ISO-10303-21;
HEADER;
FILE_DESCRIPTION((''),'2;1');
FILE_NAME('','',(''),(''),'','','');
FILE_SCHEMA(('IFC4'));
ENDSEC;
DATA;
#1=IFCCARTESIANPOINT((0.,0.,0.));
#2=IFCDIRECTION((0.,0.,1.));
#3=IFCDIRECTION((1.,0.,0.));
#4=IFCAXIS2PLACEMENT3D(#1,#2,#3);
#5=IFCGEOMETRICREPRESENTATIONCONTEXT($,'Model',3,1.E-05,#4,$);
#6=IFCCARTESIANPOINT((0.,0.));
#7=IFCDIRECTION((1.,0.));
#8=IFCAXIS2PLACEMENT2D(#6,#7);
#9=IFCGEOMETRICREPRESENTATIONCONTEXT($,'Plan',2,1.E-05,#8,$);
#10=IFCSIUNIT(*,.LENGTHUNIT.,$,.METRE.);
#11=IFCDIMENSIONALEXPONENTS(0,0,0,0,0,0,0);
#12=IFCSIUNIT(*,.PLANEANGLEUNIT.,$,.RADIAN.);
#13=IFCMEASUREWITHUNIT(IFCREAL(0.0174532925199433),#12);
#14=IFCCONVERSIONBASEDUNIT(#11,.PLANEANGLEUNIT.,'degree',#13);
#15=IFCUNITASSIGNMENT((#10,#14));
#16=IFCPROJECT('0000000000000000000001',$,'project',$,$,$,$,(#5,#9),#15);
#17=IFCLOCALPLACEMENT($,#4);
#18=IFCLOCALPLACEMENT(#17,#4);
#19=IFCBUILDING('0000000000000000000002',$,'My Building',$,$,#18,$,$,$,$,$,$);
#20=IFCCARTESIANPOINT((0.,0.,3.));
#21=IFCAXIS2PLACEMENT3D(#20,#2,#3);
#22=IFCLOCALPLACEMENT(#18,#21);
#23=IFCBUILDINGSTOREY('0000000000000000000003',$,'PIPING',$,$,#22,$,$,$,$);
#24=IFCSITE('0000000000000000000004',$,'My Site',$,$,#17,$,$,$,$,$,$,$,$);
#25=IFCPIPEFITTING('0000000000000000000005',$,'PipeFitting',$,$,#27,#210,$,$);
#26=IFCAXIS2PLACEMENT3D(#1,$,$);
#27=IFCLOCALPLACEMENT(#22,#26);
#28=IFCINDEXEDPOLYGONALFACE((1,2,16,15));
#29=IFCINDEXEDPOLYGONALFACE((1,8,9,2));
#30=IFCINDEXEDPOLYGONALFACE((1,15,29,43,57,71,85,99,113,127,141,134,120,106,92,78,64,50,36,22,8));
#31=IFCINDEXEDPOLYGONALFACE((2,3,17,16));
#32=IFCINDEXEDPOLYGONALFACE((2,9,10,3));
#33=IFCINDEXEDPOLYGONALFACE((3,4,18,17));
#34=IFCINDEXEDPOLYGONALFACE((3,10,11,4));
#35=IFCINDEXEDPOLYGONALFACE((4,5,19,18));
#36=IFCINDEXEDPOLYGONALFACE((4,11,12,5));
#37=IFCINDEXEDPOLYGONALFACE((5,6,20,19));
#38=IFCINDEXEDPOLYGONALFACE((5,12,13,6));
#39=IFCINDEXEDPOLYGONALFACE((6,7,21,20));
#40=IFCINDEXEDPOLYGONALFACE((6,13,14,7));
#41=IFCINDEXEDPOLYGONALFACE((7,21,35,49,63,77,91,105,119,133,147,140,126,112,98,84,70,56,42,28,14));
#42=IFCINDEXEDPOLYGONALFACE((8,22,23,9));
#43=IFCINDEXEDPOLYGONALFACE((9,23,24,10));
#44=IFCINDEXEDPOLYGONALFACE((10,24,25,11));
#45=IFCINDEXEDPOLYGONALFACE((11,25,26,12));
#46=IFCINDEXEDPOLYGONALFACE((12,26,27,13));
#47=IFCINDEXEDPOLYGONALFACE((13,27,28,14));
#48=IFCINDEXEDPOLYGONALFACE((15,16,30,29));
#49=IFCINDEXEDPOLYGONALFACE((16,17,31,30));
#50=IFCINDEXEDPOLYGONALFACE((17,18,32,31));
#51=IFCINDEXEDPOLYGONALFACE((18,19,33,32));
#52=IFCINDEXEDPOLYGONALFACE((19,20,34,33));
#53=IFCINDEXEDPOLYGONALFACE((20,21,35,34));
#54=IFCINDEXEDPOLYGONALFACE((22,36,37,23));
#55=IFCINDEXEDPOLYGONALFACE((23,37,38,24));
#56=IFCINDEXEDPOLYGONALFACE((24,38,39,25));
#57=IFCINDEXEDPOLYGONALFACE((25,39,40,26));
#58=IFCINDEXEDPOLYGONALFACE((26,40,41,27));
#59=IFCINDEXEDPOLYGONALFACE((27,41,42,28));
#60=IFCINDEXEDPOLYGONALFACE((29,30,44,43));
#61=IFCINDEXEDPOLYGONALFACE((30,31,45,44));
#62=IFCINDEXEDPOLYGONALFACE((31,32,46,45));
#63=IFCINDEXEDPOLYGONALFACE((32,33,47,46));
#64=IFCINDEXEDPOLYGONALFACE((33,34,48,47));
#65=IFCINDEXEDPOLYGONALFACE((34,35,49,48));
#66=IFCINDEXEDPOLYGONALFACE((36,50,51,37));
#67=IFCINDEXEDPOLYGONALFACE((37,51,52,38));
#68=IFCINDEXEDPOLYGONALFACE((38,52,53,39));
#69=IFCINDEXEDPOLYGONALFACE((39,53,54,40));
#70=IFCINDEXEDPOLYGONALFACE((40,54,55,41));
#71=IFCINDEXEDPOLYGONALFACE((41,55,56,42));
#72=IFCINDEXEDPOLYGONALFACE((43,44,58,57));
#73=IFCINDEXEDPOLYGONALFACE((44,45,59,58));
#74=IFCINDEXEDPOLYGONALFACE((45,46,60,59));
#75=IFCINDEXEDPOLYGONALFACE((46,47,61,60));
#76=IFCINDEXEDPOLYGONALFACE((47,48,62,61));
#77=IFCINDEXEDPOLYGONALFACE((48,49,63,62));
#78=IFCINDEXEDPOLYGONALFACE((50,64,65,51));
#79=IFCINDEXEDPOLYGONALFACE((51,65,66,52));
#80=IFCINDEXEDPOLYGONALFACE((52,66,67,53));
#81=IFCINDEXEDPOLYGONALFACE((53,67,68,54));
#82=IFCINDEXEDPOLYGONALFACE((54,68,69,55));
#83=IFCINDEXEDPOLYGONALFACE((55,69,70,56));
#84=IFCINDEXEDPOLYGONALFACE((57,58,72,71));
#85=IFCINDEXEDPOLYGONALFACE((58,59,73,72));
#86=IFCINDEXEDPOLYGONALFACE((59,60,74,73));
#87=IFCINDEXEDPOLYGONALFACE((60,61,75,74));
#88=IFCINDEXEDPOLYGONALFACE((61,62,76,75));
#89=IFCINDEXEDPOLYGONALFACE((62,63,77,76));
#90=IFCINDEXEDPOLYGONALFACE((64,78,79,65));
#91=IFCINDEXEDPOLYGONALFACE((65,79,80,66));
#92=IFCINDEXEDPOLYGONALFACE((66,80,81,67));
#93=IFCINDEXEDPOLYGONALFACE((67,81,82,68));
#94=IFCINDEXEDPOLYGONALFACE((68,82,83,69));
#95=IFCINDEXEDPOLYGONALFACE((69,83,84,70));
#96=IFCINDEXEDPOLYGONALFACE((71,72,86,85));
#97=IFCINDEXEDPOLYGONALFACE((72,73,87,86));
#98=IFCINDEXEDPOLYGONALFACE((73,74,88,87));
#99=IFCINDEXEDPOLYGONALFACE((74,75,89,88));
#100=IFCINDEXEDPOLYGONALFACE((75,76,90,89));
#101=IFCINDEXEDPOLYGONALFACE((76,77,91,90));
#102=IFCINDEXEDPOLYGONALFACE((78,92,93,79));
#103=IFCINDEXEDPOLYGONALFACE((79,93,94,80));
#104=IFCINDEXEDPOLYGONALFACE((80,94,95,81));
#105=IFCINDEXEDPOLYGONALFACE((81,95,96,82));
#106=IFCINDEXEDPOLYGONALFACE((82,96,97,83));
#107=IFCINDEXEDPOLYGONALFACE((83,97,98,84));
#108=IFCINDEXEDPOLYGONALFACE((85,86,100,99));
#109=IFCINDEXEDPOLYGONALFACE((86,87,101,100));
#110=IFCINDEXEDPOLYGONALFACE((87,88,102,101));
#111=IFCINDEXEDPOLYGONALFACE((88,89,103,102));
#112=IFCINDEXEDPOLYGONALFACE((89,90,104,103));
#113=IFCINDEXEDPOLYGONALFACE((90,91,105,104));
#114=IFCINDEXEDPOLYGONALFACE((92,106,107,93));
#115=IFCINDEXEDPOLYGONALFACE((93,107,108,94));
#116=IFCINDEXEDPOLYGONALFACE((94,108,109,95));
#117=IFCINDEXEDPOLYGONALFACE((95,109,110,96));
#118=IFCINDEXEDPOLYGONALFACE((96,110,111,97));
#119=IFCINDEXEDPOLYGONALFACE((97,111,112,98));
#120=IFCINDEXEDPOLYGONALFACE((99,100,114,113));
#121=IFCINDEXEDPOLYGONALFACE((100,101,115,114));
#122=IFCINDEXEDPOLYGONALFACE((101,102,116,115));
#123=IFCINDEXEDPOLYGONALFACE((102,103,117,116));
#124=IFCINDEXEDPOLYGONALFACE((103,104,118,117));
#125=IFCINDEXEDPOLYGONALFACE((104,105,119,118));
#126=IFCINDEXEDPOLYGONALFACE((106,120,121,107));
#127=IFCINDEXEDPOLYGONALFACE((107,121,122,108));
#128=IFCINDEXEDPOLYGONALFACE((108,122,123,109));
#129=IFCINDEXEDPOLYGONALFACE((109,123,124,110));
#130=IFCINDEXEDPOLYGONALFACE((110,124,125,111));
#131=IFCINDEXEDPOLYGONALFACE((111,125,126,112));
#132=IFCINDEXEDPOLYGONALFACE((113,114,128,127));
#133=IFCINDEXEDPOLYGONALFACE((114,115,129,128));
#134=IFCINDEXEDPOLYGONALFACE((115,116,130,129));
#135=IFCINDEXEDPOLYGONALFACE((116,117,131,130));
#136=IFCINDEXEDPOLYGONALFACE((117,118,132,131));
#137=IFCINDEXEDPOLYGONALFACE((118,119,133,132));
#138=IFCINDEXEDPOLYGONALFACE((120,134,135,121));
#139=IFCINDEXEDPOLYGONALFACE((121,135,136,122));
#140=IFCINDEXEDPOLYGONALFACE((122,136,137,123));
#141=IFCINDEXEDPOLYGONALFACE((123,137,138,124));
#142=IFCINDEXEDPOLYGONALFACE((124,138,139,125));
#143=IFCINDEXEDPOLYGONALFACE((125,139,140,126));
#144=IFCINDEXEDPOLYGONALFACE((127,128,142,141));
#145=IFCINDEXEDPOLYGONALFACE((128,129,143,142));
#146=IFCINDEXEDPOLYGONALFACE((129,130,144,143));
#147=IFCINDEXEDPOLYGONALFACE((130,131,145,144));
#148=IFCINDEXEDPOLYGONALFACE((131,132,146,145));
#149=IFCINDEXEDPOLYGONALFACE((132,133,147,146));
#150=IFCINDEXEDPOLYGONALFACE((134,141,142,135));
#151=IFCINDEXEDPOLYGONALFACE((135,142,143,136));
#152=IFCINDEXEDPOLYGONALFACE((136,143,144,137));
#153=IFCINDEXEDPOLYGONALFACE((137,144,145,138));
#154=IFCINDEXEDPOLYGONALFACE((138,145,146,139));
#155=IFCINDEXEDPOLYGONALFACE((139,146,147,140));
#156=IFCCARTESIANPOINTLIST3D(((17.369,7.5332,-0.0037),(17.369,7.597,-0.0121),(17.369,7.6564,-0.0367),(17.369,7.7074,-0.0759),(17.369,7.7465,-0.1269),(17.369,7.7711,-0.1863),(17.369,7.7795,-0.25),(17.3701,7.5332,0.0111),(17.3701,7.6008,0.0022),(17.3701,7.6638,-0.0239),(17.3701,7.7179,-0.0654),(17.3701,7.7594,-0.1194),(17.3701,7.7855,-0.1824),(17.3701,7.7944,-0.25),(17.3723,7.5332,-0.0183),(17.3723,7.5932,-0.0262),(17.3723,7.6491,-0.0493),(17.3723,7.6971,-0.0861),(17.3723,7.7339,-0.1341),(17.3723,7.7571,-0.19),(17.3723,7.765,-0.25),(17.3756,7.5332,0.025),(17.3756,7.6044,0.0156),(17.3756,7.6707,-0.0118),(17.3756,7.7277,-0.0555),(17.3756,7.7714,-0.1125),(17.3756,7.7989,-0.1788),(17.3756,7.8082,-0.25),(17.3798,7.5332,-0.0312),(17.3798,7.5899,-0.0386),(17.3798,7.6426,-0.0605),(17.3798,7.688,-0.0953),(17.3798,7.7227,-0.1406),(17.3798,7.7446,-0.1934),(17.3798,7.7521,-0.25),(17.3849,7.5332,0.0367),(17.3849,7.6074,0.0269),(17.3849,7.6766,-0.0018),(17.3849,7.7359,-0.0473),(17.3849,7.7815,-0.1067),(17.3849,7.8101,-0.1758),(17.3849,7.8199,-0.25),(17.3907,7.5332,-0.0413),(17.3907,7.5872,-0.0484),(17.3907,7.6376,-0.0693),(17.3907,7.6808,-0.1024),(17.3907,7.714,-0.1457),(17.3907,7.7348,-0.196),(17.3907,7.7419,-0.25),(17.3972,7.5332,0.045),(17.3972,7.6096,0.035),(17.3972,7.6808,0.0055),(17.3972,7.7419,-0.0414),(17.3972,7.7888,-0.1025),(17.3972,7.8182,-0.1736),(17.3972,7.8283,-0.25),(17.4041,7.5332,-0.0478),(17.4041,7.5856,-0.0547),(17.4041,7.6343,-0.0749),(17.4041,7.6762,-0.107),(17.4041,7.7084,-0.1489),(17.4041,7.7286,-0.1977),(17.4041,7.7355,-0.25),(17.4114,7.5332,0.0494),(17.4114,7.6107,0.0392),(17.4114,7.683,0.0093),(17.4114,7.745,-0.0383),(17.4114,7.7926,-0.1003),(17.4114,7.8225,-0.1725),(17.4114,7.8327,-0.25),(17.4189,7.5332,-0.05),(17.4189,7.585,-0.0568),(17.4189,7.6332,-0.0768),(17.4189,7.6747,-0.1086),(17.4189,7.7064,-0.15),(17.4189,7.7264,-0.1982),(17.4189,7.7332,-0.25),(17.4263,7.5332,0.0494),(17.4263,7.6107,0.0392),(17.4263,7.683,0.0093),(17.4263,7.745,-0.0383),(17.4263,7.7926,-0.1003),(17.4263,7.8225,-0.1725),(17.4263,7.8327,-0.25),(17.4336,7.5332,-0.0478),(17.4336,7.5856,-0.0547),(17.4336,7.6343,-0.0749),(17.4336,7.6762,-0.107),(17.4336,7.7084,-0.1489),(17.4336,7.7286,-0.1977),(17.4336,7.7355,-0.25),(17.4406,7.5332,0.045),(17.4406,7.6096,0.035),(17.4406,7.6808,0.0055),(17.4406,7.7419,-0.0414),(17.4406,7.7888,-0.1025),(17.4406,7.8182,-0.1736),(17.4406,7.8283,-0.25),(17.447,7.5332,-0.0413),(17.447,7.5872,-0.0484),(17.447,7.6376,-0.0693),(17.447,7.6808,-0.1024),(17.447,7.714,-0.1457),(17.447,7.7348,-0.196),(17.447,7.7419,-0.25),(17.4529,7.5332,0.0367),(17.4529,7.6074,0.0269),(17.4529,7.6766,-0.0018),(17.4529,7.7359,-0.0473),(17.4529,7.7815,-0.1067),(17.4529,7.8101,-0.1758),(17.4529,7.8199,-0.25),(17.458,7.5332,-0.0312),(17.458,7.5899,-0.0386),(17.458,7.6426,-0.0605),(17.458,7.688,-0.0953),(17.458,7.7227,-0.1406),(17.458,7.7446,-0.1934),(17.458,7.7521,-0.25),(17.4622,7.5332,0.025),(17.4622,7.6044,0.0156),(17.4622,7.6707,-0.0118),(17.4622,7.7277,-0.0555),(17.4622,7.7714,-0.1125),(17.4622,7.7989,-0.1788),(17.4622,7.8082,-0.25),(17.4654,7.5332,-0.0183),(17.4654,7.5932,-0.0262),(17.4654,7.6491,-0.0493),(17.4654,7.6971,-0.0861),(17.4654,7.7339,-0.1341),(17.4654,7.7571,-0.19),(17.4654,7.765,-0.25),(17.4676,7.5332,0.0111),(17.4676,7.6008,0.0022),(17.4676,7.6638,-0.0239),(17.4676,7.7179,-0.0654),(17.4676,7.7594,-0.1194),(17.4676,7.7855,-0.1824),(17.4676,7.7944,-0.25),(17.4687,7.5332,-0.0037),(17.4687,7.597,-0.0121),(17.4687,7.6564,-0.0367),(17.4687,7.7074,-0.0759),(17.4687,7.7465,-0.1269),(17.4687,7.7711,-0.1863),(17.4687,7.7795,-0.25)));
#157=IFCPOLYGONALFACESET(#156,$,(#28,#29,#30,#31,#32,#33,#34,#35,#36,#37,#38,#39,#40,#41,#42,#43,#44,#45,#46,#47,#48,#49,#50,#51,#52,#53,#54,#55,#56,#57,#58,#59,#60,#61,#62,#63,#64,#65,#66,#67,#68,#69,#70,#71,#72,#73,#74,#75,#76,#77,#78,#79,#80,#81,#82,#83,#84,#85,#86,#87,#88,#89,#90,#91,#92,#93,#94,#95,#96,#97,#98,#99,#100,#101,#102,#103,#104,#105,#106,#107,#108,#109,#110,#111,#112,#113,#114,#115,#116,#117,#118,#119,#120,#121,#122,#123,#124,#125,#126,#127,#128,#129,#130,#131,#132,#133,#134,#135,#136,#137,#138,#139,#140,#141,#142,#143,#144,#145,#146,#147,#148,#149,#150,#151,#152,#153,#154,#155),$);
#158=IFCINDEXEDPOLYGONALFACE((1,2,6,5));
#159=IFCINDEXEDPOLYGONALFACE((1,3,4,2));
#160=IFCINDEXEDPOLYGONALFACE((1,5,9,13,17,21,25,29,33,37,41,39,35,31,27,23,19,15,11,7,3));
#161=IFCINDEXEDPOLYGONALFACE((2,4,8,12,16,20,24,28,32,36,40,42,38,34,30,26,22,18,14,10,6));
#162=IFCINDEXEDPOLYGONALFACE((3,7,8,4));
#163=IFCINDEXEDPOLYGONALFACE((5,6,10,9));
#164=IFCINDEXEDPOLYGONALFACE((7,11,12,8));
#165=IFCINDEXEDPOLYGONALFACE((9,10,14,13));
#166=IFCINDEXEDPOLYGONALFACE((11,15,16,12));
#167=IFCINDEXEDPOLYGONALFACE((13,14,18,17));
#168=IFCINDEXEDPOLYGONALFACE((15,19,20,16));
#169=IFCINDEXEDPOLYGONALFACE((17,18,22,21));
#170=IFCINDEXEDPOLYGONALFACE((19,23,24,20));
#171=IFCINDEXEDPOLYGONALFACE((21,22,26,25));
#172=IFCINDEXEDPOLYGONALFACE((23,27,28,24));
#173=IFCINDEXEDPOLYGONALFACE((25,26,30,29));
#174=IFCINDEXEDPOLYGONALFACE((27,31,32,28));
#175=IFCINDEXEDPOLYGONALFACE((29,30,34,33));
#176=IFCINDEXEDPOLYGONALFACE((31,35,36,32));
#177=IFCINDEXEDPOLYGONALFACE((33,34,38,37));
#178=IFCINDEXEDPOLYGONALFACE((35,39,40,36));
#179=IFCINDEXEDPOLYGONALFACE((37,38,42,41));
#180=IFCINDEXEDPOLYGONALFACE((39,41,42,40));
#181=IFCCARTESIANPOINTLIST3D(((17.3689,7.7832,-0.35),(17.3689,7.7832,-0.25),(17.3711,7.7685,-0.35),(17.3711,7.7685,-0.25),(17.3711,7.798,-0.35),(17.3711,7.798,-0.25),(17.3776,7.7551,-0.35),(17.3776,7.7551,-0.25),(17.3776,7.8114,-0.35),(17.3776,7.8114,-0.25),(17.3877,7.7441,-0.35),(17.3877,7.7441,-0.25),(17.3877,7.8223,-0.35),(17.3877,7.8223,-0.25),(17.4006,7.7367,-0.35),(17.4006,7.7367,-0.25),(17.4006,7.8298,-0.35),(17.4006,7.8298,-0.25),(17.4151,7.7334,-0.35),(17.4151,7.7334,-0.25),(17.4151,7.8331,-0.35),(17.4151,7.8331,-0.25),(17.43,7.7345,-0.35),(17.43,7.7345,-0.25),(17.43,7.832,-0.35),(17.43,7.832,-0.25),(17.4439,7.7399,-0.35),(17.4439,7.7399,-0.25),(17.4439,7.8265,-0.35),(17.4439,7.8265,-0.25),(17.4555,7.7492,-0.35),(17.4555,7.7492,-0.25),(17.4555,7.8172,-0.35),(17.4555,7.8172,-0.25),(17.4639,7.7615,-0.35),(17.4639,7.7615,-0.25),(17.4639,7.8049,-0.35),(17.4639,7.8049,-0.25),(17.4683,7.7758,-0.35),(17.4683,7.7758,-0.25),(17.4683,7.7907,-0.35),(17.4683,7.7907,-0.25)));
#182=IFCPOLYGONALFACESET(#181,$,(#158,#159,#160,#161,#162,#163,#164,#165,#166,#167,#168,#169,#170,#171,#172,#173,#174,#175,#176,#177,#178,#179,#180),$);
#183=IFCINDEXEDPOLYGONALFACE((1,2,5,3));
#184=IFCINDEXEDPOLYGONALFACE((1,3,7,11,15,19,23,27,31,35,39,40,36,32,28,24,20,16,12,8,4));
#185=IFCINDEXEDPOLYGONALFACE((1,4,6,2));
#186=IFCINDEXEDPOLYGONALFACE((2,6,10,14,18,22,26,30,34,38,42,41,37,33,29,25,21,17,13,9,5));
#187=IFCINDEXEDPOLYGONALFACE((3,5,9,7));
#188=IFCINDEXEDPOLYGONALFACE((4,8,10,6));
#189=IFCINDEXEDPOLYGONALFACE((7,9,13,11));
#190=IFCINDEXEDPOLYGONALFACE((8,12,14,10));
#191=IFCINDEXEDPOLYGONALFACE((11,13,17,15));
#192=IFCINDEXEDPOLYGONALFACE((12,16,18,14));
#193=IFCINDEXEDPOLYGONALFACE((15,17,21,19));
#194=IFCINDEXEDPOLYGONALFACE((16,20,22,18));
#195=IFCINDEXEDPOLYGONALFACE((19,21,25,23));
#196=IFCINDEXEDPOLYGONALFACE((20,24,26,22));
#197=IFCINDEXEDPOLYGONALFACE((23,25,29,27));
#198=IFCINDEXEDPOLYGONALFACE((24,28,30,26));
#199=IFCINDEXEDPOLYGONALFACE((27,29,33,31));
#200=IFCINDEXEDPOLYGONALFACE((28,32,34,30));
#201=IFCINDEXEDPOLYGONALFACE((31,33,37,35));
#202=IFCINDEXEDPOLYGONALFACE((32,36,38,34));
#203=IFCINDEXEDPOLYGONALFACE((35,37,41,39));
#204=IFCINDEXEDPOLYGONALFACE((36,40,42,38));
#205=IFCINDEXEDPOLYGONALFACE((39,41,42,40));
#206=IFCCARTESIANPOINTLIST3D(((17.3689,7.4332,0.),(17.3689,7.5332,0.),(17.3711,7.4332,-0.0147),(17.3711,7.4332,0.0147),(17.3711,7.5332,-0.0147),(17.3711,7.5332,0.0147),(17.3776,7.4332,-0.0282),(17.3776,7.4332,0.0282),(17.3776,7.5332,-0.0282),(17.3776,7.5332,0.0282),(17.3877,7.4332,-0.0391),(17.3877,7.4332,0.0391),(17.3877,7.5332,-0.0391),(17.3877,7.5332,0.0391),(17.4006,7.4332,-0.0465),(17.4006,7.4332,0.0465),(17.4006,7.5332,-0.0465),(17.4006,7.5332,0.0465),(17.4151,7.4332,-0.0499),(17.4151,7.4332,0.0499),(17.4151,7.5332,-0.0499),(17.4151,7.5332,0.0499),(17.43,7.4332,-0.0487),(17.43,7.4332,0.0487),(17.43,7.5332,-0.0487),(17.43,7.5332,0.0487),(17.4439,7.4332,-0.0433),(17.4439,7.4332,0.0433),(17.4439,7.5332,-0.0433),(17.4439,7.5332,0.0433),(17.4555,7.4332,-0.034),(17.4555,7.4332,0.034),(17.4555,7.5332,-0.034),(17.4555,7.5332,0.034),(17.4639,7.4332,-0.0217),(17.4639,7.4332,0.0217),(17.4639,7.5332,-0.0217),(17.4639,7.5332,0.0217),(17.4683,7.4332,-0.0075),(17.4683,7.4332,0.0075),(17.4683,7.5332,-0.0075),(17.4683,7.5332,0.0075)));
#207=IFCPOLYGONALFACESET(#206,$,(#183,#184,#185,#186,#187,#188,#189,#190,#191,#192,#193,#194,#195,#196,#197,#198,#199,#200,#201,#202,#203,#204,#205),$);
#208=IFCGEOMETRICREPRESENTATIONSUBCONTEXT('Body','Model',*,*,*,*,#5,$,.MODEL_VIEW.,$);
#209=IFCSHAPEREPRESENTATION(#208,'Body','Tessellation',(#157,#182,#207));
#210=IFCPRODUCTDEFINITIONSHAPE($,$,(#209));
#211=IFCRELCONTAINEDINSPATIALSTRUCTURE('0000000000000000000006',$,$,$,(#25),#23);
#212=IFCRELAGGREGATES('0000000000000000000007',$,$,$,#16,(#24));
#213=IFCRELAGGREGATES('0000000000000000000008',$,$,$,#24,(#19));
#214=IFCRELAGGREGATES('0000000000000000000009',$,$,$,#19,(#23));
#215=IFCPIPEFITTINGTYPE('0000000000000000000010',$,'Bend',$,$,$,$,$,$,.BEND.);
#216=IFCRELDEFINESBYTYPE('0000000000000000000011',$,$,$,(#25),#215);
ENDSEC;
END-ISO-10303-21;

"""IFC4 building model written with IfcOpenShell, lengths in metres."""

from ifc_helpers import new_model, entity, si_unit, converted_unit, frame, origin_with_axes, origin_2d_with_axis, place, context, subcontext, project, spatial, circle, extrude, source, transform, mapped, type_object, type_shapes, element, save


model = new_model("IFC4")

# Units and contexts
model_context = context("Model", 3, precision=1e-05, world=origin_with_axes())
plan_context = context("Plan", 2, precision=1e-05, world=origin_2d_with_axis())
body_context = subcontext(model_context, "Body", "Model", "MODEL_VIEW")
ifc_project = project(units=[si_unit("LENGTHUNIT", "METRE"), converted_unit("PLANEANGLEUNIT", "degree", entity("IfcReal", 0.0174532925199433), si_unit("PLANEANGLEUNIT", "RADIAN"), dimensions=[0, 0, 0, 0, 0, 0, 0])], contexts=[model_context, plan_context])

# Site, building, storey
site_placement = place(None, origin_with_axes())
site = spatial("IfcSite", under=ifc_project, at=site_placement, Name="My Site")
building_placement = place(site_placement, origin_with_axes())
building = spatial("IfcBuilding", under=site, at=building_placement, Name="My Building")
storey_placement = place(building_placement, frame((0.0, 0.0, 3.0), z_axis=(0.0, 0.0, 1.0), x_axis=(1.0, 0.0, 0.0)))
storey = spatial("IfcBuildingStorey", under=building, at=storey_placement, Name="PIPING")

# Pipe fitting
pipe_fitting_type_1 = type_object("IfcPipeFittingType", Name="Bend", PredefinedType="BEND")
shared_shape = source(origin_with_axes(), body_context, "Body", "SolidModel", [
    entity("IfcSweptDiskSolid", entity("IfcIndexedPolyCurve", entity("IfcCartesianPointList3D", [[0.0, 0.0, -0.1], [0.0, -0.0732, -0.2768], [0.0, -0.25, -0.35]]), [entity("IfcArcIndex", [1, 2, 3])]), 0.05),
    extrude(circle(Radius=0.05), origin_with_axes(), (0.0, 0.0, -1.0), 0.1),
    extrude(circle(Radius=0.05), frame((0.0, -0.25, -0.35), z_axis=(0.0, -1.0, 0.0), x_axis=(1.0, 0.0, 0.0)), (0.0, 0.0, 1.0), 0.1),
])
type_shapes(pipe_fitting_type_1, [shared_shape])
for number, where, z_axis, x_axis, name in (
    (1, (17.4189, 7.7832, -0.35), (0.0, 0.0, -1.0), (-1.0, 0.0, 0.0), "PipeFitting"),
):
    element("IfcPipeFitting", number, at=place(storey_placement, frame(where, z_axis=z_axis, x_axis=x_axis)), inside=storey, type_object=pipe_fitting_type_1, Name=name, context=body_context, shape_type="MappedRepresentation", body=[
        mapped(shared_shape, transform((0.0, 0.0, 0.0), x_axis=(1.0, 0.0, 0.0), y_axis=(0.0, 1.0, 0.0), z_axis=(0.0, 0.0, 1.0), scale=1.0)),
    ])

save(model, "model.ifc")
